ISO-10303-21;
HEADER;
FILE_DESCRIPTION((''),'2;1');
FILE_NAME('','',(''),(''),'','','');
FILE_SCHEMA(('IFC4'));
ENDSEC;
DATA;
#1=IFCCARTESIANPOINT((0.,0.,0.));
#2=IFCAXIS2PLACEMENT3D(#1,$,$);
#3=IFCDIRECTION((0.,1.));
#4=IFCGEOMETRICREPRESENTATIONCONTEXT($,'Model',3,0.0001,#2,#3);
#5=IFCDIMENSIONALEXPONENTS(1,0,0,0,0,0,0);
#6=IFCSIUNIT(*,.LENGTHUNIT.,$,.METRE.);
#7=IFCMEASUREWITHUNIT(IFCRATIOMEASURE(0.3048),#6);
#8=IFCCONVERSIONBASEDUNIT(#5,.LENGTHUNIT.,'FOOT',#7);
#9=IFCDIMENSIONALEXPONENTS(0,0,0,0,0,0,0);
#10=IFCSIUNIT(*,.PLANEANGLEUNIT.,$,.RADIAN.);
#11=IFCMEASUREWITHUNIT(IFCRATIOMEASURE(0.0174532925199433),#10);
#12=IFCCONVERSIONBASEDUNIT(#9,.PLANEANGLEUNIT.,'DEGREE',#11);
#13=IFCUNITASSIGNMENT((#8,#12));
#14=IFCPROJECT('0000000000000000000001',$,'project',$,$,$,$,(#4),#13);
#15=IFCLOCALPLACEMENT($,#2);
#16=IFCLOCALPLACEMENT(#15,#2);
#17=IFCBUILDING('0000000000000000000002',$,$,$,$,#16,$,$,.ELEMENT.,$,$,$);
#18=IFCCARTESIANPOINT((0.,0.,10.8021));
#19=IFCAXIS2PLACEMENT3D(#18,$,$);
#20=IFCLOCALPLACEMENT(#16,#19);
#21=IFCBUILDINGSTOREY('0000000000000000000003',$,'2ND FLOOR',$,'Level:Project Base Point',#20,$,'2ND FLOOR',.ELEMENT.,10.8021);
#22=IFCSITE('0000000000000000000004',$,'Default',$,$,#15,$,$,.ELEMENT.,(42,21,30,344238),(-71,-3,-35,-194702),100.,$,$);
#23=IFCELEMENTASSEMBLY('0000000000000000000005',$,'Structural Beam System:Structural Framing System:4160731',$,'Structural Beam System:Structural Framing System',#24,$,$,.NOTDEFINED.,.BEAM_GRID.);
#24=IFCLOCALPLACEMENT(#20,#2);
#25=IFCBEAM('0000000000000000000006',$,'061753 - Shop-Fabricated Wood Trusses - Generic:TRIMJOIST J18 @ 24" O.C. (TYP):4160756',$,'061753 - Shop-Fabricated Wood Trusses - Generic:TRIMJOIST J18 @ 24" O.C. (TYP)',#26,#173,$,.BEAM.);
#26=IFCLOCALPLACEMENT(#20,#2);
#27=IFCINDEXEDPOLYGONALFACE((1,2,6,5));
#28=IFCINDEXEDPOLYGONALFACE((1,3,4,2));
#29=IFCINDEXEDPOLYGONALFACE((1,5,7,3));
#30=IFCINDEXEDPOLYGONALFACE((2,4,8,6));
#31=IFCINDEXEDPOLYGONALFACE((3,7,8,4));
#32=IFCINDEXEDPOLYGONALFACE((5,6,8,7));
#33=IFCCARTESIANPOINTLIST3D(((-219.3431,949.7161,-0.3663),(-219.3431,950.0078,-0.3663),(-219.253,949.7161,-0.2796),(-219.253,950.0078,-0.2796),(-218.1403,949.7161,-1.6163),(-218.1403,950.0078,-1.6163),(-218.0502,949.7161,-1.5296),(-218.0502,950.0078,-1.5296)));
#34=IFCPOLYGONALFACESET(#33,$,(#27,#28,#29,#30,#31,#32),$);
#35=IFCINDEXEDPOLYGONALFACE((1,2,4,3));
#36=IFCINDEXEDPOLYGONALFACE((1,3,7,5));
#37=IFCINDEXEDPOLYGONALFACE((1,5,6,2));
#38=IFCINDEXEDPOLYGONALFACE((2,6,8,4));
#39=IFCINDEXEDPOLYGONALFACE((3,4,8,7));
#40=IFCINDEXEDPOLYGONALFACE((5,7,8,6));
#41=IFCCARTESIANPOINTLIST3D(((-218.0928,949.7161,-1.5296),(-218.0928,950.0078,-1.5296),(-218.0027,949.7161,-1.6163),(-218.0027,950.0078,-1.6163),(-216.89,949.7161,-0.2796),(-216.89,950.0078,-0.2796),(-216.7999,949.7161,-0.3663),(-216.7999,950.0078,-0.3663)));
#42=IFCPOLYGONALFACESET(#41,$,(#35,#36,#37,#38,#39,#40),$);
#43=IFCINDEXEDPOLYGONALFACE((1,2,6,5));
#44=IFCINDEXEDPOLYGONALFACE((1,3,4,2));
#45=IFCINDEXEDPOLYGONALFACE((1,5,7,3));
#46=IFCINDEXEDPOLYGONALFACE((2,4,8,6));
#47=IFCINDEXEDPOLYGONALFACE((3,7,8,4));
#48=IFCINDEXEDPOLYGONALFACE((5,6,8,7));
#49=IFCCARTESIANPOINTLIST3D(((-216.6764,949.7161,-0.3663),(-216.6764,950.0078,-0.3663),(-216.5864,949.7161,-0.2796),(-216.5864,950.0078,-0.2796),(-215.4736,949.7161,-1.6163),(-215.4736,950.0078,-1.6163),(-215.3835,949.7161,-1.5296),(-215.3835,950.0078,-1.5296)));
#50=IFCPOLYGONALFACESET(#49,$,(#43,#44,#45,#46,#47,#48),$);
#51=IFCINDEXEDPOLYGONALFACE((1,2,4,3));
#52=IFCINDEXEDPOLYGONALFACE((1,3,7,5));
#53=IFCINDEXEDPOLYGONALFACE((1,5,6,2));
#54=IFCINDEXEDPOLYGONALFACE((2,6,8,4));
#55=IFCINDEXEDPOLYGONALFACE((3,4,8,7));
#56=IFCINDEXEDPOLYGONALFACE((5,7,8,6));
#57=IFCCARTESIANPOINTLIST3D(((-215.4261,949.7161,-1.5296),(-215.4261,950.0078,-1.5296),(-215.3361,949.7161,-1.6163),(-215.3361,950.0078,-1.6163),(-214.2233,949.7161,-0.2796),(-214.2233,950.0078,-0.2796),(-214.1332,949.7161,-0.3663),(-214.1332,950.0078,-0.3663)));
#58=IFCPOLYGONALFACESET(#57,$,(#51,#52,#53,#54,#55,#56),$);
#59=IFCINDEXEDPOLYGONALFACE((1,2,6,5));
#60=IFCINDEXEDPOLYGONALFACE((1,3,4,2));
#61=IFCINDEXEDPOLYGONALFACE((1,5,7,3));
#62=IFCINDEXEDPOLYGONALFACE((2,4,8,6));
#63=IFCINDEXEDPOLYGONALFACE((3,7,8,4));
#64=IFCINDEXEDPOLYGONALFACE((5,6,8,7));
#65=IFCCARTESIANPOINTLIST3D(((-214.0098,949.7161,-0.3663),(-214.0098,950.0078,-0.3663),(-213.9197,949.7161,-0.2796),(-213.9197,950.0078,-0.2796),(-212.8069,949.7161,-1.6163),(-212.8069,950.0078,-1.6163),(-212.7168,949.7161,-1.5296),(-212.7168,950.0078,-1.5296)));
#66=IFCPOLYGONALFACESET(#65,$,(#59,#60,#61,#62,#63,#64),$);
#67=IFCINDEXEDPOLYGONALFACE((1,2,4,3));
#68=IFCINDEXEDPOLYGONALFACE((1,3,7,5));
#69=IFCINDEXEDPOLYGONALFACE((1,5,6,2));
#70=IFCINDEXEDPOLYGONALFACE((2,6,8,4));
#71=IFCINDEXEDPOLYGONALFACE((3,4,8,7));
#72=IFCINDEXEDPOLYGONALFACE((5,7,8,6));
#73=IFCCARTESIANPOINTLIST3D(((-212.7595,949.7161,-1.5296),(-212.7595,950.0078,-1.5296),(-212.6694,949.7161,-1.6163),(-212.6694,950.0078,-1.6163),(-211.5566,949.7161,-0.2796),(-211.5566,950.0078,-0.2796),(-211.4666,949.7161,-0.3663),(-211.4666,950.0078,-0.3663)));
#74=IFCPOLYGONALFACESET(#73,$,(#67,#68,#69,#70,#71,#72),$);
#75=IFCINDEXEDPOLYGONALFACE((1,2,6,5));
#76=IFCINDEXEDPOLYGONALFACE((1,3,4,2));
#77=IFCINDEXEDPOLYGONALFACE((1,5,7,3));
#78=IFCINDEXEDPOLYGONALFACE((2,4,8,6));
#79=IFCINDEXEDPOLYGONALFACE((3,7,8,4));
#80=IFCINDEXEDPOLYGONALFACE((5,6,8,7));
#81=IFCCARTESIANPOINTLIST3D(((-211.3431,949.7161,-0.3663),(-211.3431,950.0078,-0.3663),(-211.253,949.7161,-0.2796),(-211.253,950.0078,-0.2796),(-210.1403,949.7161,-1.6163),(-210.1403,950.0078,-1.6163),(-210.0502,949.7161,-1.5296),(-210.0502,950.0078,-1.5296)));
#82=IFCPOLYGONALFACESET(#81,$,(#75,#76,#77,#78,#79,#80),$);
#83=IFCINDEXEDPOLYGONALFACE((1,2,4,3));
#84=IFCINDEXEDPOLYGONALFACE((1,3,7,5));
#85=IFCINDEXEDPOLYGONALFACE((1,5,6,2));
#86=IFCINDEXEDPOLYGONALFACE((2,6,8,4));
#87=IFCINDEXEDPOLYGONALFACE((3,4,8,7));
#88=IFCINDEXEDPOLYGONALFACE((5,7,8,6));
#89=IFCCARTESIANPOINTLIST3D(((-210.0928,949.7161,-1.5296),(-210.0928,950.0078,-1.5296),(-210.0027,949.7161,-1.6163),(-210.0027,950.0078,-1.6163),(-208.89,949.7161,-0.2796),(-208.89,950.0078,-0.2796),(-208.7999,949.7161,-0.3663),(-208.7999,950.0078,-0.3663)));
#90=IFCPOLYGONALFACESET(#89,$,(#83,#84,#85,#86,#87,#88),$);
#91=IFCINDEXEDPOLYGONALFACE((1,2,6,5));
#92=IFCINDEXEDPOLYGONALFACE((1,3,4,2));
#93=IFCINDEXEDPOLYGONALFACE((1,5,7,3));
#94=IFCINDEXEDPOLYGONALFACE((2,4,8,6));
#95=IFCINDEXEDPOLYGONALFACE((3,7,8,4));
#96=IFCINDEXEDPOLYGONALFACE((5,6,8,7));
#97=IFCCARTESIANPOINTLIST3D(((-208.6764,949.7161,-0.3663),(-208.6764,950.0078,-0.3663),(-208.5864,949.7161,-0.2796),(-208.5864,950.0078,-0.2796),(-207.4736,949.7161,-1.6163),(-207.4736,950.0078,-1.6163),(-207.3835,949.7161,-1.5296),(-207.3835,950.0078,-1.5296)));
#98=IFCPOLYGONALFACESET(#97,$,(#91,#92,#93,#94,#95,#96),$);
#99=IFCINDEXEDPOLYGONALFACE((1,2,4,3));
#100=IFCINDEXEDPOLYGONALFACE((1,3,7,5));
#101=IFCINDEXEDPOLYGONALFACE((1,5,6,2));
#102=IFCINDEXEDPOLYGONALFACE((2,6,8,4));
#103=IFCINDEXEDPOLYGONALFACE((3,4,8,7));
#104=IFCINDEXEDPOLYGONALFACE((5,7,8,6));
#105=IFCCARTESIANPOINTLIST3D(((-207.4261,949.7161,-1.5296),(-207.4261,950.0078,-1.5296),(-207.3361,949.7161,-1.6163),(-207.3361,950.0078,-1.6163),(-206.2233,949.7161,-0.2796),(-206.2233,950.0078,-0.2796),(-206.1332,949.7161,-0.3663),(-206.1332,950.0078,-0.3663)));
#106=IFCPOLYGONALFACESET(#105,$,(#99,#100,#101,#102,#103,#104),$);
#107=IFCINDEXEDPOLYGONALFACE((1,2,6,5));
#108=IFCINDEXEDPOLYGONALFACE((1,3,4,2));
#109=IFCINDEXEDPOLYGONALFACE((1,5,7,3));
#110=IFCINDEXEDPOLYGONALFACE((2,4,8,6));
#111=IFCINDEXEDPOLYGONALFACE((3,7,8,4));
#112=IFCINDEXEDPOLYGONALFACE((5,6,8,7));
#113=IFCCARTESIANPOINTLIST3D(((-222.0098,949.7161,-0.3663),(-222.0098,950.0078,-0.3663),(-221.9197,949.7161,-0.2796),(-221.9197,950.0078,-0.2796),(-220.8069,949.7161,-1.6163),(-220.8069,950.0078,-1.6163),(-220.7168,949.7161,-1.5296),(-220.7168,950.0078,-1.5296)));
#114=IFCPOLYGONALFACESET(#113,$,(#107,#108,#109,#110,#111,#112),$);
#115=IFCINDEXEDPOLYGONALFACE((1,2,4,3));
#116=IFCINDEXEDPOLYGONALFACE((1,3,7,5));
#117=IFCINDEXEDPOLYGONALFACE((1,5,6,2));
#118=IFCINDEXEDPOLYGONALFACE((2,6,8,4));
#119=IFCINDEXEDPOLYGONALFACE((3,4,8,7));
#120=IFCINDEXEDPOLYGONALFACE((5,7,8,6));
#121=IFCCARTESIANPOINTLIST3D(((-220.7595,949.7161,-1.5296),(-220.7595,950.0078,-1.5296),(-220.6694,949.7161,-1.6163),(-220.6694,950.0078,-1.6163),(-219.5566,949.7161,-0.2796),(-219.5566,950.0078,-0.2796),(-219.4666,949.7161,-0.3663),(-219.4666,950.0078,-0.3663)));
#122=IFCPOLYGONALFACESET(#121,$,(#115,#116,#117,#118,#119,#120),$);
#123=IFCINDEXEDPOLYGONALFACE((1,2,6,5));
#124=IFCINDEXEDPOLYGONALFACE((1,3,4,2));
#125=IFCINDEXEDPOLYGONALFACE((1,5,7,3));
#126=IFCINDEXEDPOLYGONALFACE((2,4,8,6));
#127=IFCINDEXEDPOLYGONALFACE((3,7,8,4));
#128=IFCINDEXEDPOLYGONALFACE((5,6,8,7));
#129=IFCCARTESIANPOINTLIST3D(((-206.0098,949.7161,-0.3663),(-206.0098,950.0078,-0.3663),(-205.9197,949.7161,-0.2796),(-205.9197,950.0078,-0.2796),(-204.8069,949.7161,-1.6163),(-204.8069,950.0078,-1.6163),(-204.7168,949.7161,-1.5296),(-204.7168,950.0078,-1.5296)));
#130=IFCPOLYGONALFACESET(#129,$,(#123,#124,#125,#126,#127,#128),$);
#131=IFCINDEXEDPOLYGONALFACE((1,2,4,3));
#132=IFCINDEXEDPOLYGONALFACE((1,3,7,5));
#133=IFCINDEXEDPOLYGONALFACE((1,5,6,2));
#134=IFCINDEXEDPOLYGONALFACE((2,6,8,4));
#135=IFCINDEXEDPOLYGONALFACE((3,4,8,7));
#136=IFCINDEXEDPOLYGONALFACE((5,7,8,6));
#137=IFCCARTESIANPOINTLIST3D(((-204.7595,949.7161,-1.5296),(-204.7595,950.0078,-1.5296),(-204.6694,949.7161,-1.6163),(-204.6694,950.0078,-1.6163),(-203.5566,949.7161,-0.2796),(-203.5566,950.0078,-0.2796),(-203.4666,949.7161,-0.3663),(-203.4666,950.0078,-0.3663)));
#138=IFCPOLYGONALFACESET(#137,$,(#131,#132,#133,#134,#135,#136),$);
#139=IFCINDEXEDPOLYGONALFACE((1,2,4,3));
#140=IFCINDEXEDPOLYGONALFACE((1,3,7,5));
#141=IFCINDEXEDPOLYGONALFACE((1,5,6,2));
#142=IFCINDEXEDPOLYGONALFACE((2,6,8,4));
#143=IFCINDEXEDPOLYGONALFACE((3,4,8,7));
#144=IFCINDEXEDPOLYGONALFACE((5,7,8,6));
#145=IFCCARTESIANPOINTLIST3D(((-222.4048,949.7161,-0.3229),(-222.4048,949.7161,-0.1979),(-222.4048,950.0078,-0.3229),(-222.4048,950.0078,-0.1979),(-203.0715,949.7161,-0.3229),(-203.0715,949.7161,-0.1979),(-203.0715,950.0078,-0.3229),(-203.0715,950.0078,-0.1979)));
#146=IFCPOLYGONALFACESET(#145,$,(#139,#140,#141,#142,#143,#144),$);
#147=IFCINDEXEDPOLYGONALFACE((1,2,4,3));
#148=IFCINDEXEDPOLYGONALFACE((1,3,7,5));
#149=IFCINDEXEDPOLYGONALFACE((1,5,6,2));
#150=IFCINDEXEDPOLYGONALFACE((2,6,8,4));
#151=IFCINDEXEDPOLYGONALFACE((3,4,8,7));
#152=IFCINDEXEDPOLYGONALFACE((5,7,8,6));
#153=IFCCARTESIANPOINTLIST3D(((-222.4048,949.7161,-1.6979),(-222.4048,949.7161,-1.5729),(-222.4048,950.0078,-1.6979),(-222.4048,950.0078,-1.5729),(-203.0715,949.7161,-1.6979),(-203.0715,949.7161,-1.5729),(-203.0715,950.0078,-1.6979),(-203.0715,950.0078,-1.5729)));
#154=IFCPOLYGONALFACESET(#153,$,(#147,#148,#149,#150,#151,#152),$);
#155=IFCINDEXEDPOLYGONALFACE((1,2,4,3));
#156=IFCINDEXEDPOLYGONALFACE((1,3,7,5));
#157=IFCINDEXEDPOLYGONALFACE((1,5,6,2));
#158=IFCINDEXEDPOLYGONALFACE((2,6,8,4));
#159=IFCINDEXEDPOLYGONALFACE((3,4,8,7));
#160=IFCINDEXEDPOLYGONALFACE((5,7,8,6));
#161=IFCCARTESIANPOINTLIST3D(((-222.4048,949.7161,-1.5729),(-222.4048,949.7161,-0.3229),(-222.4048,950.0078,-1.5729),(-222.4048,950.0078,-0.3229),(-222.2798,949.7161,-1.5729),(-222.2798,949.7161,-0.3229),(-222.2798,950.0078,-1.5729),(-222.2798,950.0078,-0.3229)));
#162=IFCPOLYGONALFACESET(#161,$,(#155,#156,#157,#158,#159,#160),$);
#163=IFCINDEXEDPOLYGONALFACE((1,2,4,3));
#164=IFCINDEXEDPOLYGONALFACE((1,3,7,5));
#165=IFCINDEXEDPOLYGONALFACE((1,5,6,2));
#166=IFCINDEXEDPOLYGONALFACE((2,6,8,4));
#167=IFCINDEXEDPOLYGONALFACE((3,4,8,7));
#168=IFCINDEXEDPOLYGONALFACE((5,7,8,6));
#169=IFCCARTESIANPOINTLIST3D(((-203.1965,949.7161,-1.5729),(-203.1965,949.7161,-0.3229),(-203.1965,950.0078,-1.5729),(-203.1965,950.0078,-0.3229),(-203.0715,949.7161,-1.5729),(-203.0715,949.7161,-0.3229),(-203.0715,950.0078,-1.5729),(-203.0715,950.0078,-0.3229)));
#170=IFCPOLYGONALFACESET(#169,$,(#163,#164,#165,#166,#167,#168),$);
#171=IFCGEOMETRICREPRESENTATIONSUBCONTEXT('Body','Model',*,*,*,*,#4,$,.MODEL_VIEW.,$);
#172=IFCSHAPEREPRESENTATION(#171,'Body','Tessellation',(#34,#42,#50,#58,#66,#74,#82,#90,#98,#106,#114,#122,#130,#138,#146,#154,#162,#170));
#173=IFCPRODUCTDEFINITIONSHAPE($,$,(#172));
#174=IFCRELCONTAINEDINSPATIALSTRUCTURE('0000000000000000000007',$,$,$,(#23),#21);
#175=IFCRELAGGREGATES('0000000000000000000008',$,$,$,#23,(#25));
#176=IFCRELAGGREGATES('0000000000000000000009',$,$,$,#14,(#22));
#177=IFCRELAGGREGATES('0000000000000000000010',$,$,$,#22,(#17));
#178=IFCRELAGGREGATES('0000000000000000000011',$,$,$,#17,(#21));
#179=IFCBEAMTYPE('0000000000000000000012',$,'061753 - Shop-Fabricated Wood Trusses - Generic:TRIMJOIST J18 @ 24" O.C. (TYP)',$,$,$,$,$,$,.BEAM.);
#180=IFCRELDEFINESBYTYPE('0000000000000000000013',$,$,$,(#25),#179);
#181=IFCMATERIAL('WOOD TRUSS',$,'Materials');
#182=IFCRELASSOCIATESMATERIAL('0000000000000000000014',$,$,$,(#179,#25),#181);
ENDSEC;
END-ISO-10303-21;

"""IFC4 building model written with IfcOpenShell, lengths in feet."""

from ifc_helpers import new_model, entity, si_unit, converted_unit, direction, frame, frame_2d, origin, origin_2d_with_axis, place, context, subcontext, project, spatial, rectangle, extrude, source, transform, mapped, material, material_profile, profile_set, profile_usage, type_object, type_shapes, element, aggregate, save


model = new_model("IFC4")

# Units and contexts
model_context = context("Model", 3, precision=0.0001, world=origin(), true_north=direction((0.0, 1.0)))
body_context = subcontext(model_context, "Body", "Model", "MODEL_VIEW")
ifc_project = project(units=[converted_unit("LENGTHUNIT", "FOOT", entity("IfcRatioMeasure", 0.3048), si_unit("LENGTHUNIT", "METRE"), dimensions=[1, 0, 0, 0, 0, 0, 0]), converted_unit("PLANEANGLEUNIT", "DEGREE", entity("IfcRatioMeasure", 0.0174532925199433), si_unit("PLANEANGLEUNIT", "RADIAN"), dimensions=[0, 0, 0, 0, 0, 0, 0])], contexts=[model_context])

# Site, building, storey
site_placement = place(None, origin())
site = spatial("IfcSite", under=ifc_project, at=site_placement, Name="Default", CompositionType="ELEMENT", RefLatitude=(42, 21, 30, 344238), RefLongitude=(-71, -3, -35, -194702), RefElevation=100.0)
building_placement = place(site_placement, origin())
building = spatial("IfcBuilding", under=site, at=building_placement, CompositionType="ELEMENT")
storey_placement = place(building_placement, frame((0.0, 0.0, 10.8021)))
storey = spatial("IfcBuildingStorey", under=building, at=storey_placement, Name="2ND FLOOR", ObjectType="Level:Project Base Point", LongName="2ND FLOOR", CompositionType="ELEMENT", Elevation=10.8021)

# Element assembly, beam
ifc_material_1 = material(Name="WOOD TRUSS", Category="Materials")
ifc_material_profile_1 = material_profile(ifc_material_1, rectangle(XDim=1.7347, YDim=0.125, at=frame_2d((0.0, 0.0), x_axis=(1.0, 0.0))), Name="TRIMJOIST J18 @ 24\" O.C. (TYP)")
ifc_material_profile_2 = material_profile(ifc_material_1, rectangle(XDim=1.7347, YDim=0.125, at=frame_2d((0.0, 0.0), x_axis=(1.0, 0.0))), Name="TRIMJOIST J18 @ 24\" O.C. (TYP)")
ifc_material_profile_3 = material_profile(ifc_material_1, rectangle(XDim=1.7347, YDim=0.125, at=frame_2d((0.0, 0.0), x_axis=(1.0, 0.0))), Name="TRIMJOIST J18 @ 24\" O.C. (TYP)")
ifc_material_profile_4 = material_profile(ifc_material_1, rectangle(XDim=1.7347, YDim=0.125, at=frame_2d((0.0, 0.0), x_axis=(1.0, 0.0))), Name="TRIMJOIST J18 @ 24\" O.C. (TYP)")
ifc_material_profile_5 = material_profile(ifc_material_1, rectangle(XDim=1.7347, YDim=0.125, at=frame_2d((0.0, 0.0), x_axis=(1.0, 0.0))), Name="TRIMJOIST J18 @ 24\" O.C. (TYP)")
ifc_material_profile_6 = material_profile(ifc_material_1, rectangle(XDim=1.7347, YDim=0.125, at=frame_2d((0.0, 0.0), x_axis=(1.0, 0.0))), Name="TRIMJOIST J18 @ 24\" O.C. (TYP)")
ifc_material_profile_7 = material_profile(ifc_material_1, rectangle(XDim=1.7347, YDim=0.125, at=frame_2d((0.0, 0.0), x_axis=(1.0, 0.0))), Name="TRIMJOIST J18 @ 24\" O.C. (TYP)")
ifc_material_profile_8 = material_profile(ifc_material_1, rectangle(XDim=1.7347, YDim=0.125, at=frame_2d((0.0, 0.0), x_axis=(1.0, 0.0))), Name="TRIMJOIST J18 @ 24\" O.C. (TYP)")
ifc_material_profile_9 = material_profile(ifc_material_1, rectangle(XDim=1.7347, YDim=0.125, at=frame_2d((0.0, 0.0), x_axis=(1.0, 0.0))), Name="TRIMJOIST J18 @ 24\" O.C. (TYP)")
ifc_material_profile_10 = material_profile(ifc_material_1, rectangle(XDim=1.7347, YDim=0.125, at=origin_2d_with_axis()), Name="TRIMJOIST J18 @ 24\" O.C. (TYP)")
ifc_material_profile_11 = material_profile(ifc_material_1, rectangle(XDim=0.125, YDim=0.2917, at=origin_2d_with_axis()), Name="TRIMJOIST J18 @ 24\" O.C. (TYP)")
ifc_material_profile_12 = material_profile(ifc_material_1, rectangle(XDim=0.125, YDim=0.2917, at=origin_2d_with_axis()), Name="TRIMJOIST J18 @ 24\" O.C. (TYP)")
ifc_material_profile_13 = material_profile(ifc_material_1, rectangle(XDim=1.25, YDim=0.2917, at=origin_2d_with_axis()), Name="TRIMJOIST J18 @ 24\" O.C. (TYP)")
ifc_material_profile_14 = material_profile(ifc_material_1, rectangle(XDim=1.25, YDim=0.2917, at=origin_2d_with_axis()), Name="TRIMJOIST J18 @ 24\" O.C. (TYP)")
ifc_profile_set_1 = profile_set([ifc_material_profile_1, ifc_material_profile_2, ifc_material_profile_3, ifc_material_profile_4, ifc_material_profile_5, ifc_material_profile_6, ifc_material_profile_7, ifc_material_profile_8, ifc_material_profile_9, ifc_material_profile_10, ifc_material_profile_11, ifc_material_profile_12, ifc_material_profile_13, ifc_material_profile_14], Name="TRIMJOIST J18 @ 24\" O.C. (TYP)")
beam_type_1 = type_object("IfcBeamType", Name="061753 - Shop-Fabricated Wood Trusses - Generic:TRIMJOIST J18 @ 24\" O.C. (TYP)", PredefinedType="BEAM", material=ifc_profile_set_1)
shared_shape_1 = source(origin(), body_context, "Body", "SweptSolid", [
    extrude(rectangle(XDim=1.7347, YDim=0.125, at=frame_2d((0.0, 0.0), x_axis=(1.0, 0.0))), frame((5.9585, -0.1458, 0.0), z_axis=(0.0, 1.0, 0.0), x_axis=(0.693383, 0.0, 0.720569)), (0.0, 0.0, 1.0), 0.2917),
    extrude(rectangle(XDim=1.7347, YDim=0.125, at=origin_2d_with_axis()), frame((4.7082, -0.1458, 0.0), z_axis=(0.0, 1.0, 0.0), x_axis=(0.693383, 0.0, -0.720569)), (0.0, 0.0, 1.0), 0.2917),
    extrude(rectangle(XDim=1.7347, YDim=0.125, at=frame_2d((0.0, 0.0), x_axis=(1.0, 0.0))), frame((3.2918, -0.1458, 0.0), z_axis=(0.0, 1.0, 0.0), x_axis=(0.693383, 0.0, 0.720569)), (0.0, 0.0, 1.0), 0.2917),
    extrude(rectangle(XDim=1.7347, YDim=0.125, at=frame_2d((0.0, 0.0), x_axis=(1.0, 0.0))), frame((2.0415, -0.1458, 0.0), z_axis=(0.0, 1.0, 0.0), x_axis=(0.693383, 0.0, -0.720569)), (0.0, 0.0, 1.0), 0.2917),
    extrude(rectangle(XDim=1.7347, YDim=0.125, at=frame_2d((0.0, 0.0), x_axis=(1.0, 0.0))), frame((0.6251, -0.1458, 0.0), z_axis=(0.0, 1.0, 0.0), x_axis=(0.693383, 0.0, 0.720569)), (0.0, 0.0, 1.0), 0.2917),
    extrude(rectangle(XDim=1.7347, YDim=0.125, at=frame_2d((0.0, 0.0), x_axis=(1.0, 0.0))), frame((-0.6251, -0.1458, 0.0), z_axis=(0.0, 1.0, 0.0), x_axis=(0.693383, 0.0, -0.720569)), (0.0, 0.0, 1.0), 0.2917),
    extrude(rectangle(XDim=1.7347, YDim=0.125, at=frame_2d((0.0, 0.0), x_axis=(1.0, 0.0))), frame((-2.0415, -0.1458, 0.0), z_axis=(0.0, 1.0, 0.0), x_axis=(0.693383, 0.0, 0.720569)), (0.0, 0.0, 1.0), 0.2917),
    extrude(rectangle(XDim=1.7347, YDim=0.125, at=origin_2d_with_axis()), frame((-3.2918, -0.1458, 0.0), z_axis=(0.0, 1.0, 0.0), x_axis=(0.693383, 0.0, -0.720569)), (0.0, 0.0, 1.0), 0.2917),
    extrude(rectangle(XDim=1.7347, YDim=0.125, at=frame_2d((0.0, 0.0), x_axis=(1.0, 0.0))), frame((-4.7082, -0.1458, 0.0), z_axis=(0.0, 1.0, 0.0), x_axis=(0.693383, 0.0, 0.720569)), (0.0, 0.0, 1.0), 0.2917),
    extrude(rectangle(XDim=1.7347, YDim=0.125, at=frame_2d((0.0, 0.0), x_axis=(1.0, 0.0))), frame((-5.9585, -0.1458, 0.0), z_axis=(0.0, 1.0, 0.0), x_axis=(0.693383, 0.0, -0.720569)), (0.0, 0.0, 1.0), 0.2917),
    extrude(rectangle(XDim=1.7347, YDim=0.125, at=frame_2d((0.0, 0.0), x_axis=(1.0, 0.0))), frame((8.6251, -0.1458, 0.0), z_axis=(0.0, 1.0, 0.0), x_axis=(0.693383, 0.0, 0.720569)), (0.0, 0.0, 1.0), 0.2917),
    extrude(rectangle(XDim=1.7347, YDim=0.125, at=origin_2d_with_axis()), frame((7.3749, -0.1458, 0.0), z_axis=(0.0, 1.0, 0.0), x_axis=(0.693383, 0.0, -0.720569)), (0.0, 0.0, 1.0), 0.2917),
    extrude(rectangle(XDim=1.7347, YDim=0.125, at=frame_2d((0.0, 0.0), x_axis=(1.0, 0.0))), frame((-7.3749, -0.1458, 0.0), z_axis=(0.0, 1.0, 0.0), x_axis=(0.693383, 0.0, 0.720569)), (0.0, 0.0, 1.0), 0.2917),
    extrude(rectangle(XDim=1.7347, YDim=0.125, at=origin_2d_with_axis()), frame((-8.6251, -0.1458, 0.0), z_axis=(0.0, 1.0, 0.0), x_axis=(0.693383, 0.0, -0.720569)), (0.0, 0.0, 1.0), 0.2917),
    extrude(rectangle(XDim=0.125, YDim=0.2917, at=origin_2d_with_axis()), frame((-9.6667, 0.0, 0.6875), z_axis=(1.0, 0.0, 0.0), x_axis=(0.0, 0.0, -1.0)), (0.0, 0.0, 1.0), 19.3333),
    extrude(rectangle(XDim=0.125, YDim=0.2917, at=origin_2d_with_axis()), frame((-9.6667, 0.0, -0.6875), z_axis=(1.0, 0.0, 0.0), x_axis=(0.0, 0.0, -1.0)), (0.0, 0.0, 1.0), 19.3333),
    extrude(rectangle(XDim=1.25, YDim=0.2917, at=origin_2d_with_axis()), frame((9.5417, 0.0, 0.0), z_axis=(1.0, 0.0, 0.0), x_axis=(0.0, 0.0, -1.0)), (0.0, 0.0, 1.0), 0.125),
    extrude(rectangle(XDim=1.25, YDim=0.2917, at=origin_2d_with_axis()), frame((-9.6667, 0.0, 0.0), z_axis=(1.0, 0.0, 0.0), x_axis=(0.0, 0.0, -1.0)), (0.0, 0.0, 1.0), 0.125),
])
type_shapes(beam_type_1, [shared_shape_1])
assembly_1_placement = place(storey_placement, origin())
assembly_1 = element("IfcElementAssembly", 1, at=assembly_1_placement, inside=storey, Name="Structural Beam System:Structural Framing System:4160731", ObjectType="Structural Beam System:Structural Framing System", AssemblyPlace="NOTDEFINED", PredefinedType="BEAM_GRID")
ifc_profile_usage_1 = profile_usage(ifc_profile_set_1, cardinal=8)
beam_1_placement = place(assembly_1_placement, frame((-212.7382, 949.8619, -0.9479), z_axis=(0.0, 0.0, 1.0), x_axis=(-1.0, 0.0, 0.0)))
beam_1 = element("IfcBeam", 2, at=beam_1_placement, type_object=beam_type_1, material=ifc_profile_usage_1, Name="061753 - Shop-Fabricated Wood Trusses - Generic:TRIMJOIST J18 @ 24\" O.C. (TYP):4160756", ObjectType="061753 - Shop-Fabricated Wood Trusses - Generic:TRIMJOIST J18 @ 24\" O.C. (TYP)", PredefinedType="BEAM", context=body_context, shape_type="MappedRepresentation", body=[
    mapped(shared_shape_1, transform((0.0, 0.0, 0.0), scale=1.0)),
])
aggregate(assembly_1, [beam_1])

save(model, "model.ifc")
